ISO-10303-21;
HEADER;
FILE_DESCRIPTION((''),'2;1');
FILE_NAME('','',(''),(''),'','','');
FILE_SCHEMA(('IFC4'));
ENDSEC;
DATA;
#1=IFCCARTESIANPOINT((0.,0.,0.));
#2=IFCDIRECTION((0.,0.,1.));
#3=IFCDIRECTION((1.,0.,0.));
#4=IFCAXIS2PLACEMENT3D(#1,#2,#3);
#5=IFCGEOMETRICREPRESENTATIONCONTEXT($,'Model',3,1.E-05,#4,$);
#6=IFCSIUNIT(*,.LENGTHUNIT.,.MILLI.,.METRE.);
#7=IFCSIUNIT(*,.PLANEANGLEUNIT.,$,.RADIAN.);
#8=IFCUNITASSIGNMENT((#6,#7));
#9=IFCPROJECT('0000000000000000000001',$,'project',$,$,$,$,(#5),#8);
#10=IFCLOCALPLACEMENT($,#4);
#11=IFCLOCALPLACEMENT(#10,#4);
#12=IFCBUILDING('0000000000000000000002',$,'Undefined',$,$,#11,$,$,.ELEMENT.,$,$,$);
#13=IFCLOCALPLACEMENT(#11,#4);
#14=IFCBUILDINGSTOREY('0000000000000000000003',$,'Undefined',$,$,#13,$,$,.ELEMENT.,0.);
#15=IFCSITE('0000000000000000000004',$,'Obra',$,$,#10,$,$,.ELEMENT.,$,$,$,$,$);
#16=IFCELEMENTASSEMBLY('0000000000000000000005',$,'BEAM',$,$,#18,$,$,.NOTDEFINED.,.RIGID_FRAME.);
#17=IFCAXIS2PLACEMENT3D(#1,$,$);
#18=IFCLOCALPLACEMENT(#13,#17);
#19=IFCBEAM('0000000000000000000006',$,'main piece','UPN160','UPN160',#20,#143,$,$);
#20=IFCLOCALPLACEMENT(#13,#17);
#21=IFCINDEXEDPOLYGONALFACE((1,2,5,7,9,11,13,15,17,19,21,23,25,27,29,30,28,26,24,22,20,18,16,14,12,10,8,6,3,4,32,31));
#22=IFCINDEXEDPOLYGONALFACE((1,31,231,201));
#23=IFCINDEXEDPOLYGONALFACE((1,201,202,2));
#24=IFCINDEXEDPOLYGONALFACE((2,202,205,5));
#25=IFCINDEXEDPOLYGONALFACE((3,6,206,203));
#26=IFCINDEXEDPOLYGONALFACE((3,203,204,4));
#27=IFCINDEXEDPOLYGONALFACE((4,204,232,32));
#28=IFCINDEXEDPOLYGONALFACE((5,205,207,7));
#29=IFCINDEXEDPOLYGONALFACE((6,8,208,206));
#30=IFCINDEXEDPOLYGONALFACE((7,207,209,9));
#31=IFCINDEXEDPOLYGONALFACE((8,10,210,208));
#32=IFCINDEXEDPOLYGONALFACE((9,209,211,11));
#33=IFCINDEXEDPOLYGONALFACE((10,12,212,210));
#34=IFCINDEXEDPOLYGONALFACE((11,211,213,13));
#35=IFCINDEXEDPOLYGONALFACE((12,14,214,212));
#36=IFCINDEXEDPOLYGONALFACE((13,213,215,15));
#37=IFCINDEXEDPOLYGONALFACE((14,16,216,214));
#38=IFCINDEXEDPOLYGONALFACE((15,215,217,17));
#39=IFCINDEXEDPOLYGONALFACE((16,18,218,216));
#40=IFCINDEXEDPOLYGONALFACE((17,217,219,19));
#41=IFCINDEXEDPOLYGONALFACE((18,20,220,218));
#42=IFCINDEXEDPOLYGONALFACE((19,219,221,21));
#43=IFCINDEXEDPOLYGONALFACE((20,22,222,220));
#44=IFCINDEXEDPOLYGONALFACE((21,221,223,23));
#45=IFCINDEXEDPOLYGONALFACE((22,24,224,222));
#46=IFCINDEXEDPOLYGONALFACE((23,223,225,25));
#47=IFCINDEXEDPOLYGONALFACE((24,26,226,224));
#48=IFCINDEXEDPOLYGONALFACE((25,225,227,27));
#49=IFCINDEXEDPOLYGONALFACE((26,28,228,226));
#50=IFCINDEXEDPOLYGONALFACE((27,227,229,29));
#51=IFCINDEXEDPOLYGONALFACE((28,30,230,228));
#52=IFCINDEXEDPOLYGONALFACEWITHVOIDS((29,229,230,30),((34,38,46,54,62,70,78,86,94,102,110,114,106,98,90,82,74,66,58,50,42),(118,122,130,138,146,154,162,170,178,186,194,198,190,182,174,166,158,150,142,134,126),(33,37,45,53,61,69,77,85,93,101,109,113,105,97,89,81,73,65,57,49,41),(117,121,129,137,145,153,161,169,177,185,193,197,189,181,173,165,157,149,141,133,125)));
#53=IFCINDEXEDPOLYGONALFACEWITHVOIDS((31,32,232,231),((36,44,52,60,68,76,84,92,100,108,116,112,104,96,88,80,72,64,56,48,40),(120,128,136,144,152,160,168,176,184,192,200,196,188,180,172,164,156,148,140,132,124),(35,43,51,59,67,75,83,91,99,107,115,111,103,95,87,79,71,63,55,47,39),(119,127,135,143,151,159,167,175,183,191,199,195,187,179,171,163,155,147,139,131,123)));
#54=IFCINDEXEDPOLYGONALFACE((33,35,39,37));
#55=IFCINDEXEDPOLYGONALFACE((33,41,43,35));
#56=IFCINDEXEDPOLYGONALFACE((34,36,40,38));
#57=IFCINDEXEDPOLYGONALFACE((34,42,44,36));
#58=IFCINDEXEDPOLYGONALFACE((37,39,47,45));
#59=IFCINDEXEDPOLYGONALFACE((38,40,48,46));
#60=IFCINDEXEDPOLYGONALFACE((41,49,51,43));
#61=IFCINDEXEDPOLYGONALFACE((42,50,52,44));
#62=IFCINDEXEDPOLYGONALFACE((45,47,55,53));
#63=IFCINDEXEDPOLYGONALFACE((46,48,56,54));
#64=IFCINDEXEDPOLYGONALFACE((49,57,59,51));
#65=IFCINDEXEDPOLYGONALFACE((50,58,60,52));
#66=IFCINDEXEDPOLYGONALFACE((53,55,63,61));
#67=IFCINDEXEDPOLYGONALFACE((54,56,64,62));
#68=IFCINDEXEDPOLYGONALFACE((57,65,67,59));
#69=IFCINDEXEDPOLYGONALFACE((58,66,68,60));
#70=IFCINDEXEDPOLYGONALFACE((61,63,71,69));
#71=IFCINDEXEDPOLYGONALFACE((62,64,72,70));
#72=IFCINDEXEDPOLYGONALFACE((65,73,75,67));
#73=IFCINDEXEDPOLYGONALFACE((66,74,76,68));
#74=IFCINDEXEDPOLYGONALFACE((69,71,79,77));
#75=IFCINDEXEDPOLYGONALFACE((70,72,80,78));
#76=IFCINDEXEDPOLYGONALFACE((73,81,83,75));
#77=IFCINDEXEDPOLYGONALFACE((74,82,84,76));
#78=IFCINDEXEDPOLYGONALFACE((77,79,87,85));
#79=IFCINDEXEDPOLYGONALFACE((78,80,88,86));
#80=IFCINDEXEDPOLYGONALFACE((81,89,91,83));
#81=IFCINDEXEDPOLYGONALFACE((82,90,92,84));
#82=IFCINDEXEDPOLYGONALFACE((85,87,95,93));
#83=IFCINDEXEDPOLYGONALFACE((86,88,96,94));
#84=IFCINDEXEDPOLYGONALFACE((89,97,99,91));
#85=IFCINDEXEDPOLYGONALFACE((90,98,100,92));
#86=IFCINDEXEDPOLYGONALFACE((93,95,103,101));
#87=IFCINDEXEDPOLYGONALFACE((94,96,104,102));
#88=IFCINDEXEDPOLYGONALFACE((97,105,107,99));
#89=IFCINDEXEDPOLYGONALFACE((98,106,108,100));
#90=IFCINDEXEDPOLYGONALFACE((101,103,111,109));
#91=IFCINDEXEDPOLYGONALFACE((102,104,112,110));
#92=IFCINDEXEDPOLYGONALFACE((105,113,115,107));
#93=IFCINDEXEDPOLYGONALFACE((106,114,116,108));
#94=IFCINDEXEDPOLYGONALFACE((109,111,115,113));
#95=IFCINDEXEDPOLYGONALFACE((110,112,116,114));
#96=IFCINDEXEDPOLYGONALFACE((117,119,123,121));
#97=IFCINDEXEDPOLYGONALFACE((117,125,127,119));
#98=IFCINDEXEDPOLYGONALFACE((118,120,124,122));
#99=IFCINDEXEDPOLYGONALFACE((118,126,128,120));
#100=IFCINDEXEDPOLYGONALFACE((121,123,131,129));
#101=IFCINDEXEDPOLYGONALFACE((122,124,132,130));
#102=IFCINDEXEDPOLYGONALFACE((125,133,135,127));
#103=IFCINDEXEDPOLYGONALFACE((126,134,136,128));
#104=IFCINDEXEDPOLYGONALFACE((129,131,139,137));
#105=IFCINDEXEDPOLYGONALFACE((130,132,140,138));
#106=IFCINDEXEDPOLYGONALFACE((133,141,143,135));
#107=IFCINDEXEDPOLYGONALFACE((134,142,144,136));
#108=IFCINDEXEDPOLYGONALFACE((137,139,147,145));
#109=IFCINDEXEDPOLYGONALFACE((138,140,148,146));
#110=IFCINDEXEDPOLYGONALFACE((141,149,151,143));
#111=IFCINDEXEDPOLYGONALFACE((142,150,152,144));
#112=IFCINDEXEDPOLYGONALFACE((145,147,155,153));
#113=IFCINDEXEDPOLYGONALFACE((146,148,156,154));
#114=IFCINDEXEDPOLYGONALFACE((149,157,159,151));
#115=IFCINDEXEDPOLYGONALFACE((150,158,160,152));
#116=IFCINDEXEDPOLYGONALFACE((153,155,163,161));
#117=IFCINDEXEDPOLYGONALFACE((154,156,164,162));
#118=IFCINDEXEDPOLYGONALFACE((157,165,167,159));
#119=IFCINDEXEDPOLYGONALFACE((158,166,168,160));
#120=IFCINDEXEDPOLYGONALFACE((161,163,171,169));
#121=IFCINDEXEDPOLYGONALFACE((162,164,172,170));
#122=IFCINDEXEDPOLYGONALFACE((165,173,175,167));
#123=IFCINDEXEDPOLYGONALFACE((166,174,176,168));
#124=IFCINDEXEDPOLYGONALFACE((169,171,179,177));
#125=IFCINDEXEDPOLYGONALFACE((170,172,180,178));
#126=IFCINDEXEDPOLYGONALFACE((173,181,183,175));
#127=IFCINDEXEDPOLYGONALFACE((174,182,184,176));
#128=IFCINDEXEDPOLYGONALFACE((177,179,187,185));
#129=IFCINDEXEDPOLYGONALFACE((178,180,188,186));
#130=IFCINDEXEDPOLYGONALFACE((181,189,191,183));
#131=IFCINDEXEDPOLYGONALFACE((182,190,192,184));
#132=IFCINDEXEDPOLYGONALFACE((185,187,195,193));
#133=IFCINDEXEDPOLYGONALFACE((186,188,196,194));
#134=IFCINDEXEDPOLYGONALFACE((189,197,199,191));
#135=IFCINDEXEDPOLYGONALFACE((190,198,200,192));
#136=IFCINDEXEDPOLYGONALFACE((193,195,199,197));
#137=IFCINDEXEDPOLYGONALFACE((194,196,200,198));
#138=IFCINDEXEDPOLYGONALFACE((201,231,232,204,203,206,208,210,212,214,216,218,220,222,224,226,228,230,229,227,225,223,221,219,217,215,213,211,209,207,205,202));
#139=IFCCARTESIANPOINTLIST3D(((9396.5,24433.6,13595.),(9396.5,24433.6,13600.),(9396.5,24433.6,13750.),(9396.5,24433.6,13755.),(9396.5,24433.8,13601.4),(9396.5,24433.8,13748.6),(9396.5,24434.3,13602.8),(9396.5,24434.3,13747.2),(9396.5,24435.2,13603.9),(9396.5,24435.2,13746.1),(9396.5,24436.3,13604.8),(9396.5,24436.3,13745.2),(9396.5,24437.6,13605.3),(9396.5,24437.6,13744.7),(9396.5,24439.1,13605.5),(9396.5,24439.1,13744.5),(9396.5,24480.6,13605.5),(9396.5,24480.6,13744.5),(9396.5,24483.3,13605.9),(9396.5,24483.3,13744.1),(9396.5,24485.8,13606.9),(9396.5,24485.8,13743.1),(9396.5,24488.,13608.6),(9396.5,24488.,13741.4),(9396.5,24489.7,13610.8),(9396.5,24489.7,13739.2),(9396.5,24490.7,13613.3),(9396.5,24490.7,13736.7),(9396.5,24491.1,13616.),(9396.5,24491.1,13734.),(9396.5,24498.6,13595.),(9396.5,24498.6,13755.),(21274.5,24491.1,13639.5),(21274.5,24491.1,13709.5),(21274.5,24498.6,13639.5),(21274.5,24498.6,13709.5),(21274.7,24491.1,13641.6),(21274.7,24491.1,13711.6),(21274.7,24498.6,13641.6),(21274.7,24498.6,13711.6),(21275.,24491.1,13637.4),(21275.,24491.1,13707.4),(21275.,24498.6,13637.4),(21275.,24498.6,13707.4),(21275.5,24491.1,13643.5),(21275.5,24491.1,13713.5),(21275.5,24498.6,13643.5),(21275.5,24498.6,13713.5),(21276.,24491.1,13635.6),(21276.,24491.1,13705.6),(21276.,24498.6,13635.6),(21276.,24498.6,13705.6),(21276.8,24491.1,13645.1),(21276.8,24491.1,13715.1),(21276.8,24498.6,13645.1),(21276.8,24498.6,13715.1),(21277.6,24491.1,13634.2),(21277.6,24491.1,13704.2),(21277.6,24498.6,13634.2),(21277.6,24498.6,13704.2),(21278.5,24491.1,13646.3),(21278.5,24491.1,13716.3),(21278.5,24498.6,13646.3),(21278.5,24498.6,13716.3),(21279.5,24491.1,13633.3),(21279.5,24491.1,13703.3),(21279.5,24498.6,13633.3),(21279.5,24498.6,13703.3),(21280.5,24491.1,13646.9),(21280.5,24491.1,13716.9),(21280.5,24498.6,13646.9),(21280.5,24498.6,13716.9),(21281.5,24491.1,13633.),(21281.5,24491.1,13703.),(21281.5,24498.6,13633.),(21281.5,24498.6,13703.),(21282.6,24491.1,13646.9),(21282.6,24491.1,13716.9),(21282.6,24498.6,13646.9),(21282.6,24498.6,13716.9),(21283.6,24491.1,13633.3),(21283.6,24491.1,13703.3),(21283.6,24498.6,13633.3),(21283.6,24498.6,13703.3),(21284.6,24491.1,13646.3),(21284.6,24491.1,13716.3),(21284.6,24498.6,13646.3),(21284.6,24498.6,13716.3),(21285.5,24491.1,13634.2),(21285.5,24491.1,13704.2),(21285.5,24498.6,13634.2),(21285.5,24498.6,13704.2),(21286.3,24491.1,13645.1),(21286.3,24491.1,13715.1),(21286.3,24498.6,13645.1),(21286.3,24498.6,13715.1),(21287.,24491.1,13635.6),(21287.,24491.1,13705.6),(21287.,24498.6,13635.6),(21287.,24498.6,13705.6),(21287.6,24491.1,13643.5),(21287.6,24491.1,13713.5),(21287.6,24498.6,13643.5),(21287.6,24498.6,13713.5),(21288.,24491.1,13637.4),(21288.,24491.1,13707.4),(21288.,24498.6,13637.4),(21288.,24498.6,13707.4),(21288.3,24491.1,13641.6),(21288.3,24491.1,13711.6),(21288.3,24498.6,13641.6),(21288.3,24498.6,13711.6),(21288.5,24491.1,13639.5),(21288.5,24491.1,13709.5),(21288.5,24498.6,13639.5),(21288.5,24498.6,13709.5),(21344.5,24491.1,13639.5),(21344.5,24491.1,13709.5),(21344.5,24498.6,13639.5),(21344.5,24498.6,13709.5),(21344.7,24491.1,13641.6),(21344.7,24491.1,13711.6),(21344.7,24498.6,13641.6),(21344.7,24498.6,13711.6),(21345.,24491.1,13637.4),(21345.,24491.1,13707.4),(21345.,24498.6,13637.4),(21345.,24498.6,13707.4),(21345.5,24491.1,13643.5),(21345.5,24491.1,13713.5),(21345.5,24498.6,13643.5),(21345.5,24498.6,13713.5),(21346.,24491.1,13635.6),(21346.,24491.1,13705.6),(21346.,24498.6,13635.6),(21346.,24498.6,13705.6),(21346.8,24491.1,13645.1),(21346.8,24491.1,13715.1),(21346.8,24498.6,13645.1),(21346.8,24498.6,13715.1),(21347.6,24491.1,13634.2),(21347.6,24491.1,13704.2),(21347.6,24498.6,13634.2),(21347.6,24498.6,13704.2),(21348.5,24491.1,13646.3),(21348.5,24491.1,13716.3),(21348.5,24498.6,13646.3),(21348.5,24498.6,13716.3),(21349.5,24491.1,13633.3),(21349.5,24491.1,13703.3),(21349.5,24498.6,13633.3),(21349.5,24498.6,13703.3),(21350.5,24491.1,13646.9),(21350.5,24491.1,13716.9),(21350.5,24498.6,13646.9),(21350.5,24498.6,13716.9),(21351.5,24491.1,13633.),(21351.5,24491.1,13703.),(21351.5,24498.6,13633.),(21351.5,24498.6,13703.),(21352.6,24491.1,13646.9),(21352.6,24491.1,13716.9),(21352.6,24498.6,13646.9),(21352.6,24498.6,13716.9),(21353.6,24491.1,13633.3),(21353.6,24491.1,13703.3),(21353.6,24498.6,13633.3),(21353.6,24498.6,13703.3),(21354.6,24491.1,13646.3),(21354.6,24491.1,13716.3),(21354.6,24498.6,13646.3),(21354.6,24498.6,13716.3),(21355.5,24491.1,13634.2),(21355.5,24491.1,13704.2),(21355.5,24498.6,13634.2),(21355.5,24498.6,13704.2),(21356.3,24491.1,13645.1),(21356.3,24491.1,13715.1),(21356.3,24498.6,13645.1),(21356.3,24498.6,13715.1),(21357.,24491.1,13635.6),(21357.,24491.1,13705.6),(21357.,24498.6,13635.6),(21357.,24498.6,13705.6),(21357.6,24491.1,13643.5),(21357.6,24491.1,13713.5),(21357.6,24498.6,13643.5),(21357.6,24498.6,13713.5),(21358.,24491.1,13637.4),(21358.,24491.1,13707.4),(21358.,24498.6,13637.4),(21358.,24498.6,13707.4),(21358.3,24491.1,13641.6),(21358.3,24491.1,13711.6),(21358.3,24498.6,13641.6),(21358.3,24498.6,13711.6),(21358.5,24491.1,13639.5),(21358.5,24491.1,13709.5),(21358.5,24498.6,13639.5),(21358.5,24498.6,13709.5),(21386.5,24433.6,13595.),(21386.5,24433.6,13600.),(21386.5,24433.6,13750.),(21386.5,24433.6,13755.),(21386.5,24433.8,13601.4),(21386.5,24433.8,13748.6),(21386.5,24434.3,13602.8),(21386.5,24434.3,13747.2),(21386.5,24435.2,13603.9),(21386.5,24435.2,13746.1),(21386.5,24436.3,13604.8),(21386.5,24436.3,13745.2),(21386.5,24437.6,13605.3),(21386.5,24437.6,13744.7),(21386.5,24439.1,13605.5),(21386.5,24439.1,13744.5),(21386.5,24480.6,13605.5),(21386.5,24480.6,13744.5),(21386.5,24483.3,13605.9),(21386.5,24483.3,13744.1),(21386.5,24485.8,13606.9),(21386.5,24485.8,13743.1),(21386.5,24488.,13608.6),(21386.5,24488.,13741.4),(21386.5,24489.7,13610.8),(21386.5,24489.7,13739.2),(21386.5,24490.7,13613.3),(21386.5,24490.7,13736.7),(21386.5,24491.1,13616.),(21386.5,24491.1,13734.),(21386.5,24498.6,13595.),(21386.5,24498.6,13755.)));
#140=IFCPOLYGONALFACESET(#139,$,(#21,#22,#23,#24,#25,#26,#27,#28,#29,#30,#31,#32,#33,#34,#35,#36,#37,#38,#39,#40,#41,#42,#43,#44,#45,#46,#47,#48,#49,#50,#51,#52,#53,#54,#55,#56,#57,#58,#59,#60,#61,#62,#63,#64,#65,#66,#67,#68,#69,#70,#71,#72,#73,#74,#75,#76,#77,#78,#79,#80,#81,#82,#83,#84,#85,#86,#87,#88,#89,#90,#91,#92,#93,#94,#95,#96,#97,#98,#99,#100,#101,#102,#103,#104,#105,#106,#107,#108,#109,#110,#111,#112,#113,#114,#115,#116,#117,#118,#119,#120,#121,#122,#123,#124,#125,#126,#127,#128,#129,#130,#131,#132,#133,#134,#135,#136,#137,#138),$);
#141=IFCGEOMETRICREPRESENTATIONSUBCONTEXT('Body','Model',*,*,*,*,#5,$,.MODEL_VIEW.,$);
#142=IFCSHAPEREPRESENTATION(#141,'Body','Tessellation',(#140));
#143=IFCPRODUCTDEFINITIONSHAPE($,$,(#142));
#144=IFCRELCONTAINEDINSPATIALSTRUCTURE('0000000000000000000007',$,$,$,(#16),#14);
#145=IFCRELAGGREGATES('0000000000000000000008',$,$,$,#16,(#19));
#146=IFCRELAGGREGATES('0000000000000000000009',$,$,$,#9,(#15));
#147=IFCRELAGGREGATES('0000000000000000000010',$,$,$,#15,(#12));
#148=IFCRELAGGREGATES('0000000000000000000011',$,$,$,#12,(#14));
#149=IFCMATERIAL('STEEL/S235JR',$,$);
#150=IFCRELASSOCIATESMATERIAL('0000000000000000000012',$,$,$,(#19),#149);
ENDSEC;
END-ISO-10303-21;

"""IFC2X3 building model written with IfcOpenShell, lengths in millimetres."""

from ifc_helpers import new_model, si_unit, frame, origin_with_axes, origin_2d_with_axis, place, context, subcontext, project, spatial, circle, u_section, extrude, clip, halfspace, source, transform, mapped, material, element, aggregate, save


model = new_model("IFC2X3")

# Units and contexts
model_context = context("Model", 3, precision=1e-05, world=origin_with_axes())
body_context = subcontext(model_context, "Body", "Model", "MODEL_VIEW")
ifc_project = project(units=[si_unit("LENGTHUNIT", "METRE", prefix="MILLI"), si_unit("PLANEANGLEUNIT", "RADIAN")], contexts=[model_context])

# Site, building, storey
site_placement = place(None, origin_with_axes())
site = spatial("IfcSite", under=ifc_project, at=site_placement, Name="Obra", CompositionType="ELEMENT")
building_placement = place(site_placement, origin_with_axes())
building = spatial("IfcBuilding", under=site, at=building_placement, Name="Undefined", CompositionType="ELEMENT")
storey_placement = place(building_placement, origin_with_axes())
storey = spatial("IfcBuildingStorey", under=building, at=storey_placement, Name="Undefined", CompositionType="ELEMENT", Elevation=0.0)

# Shared definitions
ifc_material_1 = material(Name="STEEL/S235JR")

# Element assembly, beam, opening
assembly_1_placement = place(storey_placement, origin_with_axes())
assembly_1 = element("IfcElementAssembly", 1, at=assembly_1_placement, inside=storey, Name="BEAM", AssemblyPlace="NOTDEFINED", PredefinedType="RIGID_FRAME")
beam_1_placement = place(assembly_1_placement, frame((9391.5, 24466.1, 13675.0), z_axis=(0.0, 0.0, 1.0), x_axis=(1.0, 0.0, 0.0)))
beam_1 = element("IfcBeam", 2, at=beam_1_placement, material=ifc_material_1, Name="main piece", Description="UPN160", ObjectType="UPN160", context=body_context, shape_type="Clipping", body=[
    clip(clip(extrude(u_section(Depth=160.0, FlangeWidth=65.0, WebThickness=7.5, FlangeThickness=10.5, FilletRadius=10.5, EdgeRadius=5.5, at=origin_2d_with_axis()), frame((11995.0, 0.0, 0.0), z_axis=(-1.0, 0.0, 0.0), x_axis=(0.0, -1.0, 0.0)), (0.0, 0.0, 1.0), 11990.0), halfspace(frame((11995.0, 0.0, 166.3), z_axis=(1.0, 0.0, 0.0), x_axis=(0.0, 1.0, 0.0)), False)), halfspace(frame((5.0, 0.0, 166.3), z_axis=(-1.0, 0.0, 0.0), x_axis=(0.0, -1.0, 0.0)), False)),
])
shared_shape_1 = source(origin_with_axes(), body_context, "Body", "SweptSolid", [
    extrude(circle(Radius=7.0, at=origin_2d_with_axis()), frame((0.0, -3.9, 0.0), z_axis=(0.0, 1.0, 0.0), x_axis=(1.0, 0.0, 0.0)), (0.0, 0.0, 1.0), 7.7),
])
opening_1_placement = place(assembly_1_placement, frame((21351.5, 24494.8, 13710.0), z_axis=(-1.0, 0.0, 0.0), x_axis=(0.0, 0.0, -1.0)))
element("IfcOpeningElement", 3, at=opening_1_placement, cuts=beam_1, ObjectType="Opening", context=body_context, shape_type="MappedRepresentation", body=[
    mapped(shared_shape_1, transform((0.0, 0.0, 0.0))),
    mapped(shared_shape_1, transform((0.0, 0.0, 70.0))),
    mapped(shared_shape_1, transform((70.0, 0.0, 0.0))),
    mapped(shared_shape_1, transform((70.0, 0.0, 70.0))),
])

aggregate(assembly_1, [beam_1])

save(model, "model.ifc")
